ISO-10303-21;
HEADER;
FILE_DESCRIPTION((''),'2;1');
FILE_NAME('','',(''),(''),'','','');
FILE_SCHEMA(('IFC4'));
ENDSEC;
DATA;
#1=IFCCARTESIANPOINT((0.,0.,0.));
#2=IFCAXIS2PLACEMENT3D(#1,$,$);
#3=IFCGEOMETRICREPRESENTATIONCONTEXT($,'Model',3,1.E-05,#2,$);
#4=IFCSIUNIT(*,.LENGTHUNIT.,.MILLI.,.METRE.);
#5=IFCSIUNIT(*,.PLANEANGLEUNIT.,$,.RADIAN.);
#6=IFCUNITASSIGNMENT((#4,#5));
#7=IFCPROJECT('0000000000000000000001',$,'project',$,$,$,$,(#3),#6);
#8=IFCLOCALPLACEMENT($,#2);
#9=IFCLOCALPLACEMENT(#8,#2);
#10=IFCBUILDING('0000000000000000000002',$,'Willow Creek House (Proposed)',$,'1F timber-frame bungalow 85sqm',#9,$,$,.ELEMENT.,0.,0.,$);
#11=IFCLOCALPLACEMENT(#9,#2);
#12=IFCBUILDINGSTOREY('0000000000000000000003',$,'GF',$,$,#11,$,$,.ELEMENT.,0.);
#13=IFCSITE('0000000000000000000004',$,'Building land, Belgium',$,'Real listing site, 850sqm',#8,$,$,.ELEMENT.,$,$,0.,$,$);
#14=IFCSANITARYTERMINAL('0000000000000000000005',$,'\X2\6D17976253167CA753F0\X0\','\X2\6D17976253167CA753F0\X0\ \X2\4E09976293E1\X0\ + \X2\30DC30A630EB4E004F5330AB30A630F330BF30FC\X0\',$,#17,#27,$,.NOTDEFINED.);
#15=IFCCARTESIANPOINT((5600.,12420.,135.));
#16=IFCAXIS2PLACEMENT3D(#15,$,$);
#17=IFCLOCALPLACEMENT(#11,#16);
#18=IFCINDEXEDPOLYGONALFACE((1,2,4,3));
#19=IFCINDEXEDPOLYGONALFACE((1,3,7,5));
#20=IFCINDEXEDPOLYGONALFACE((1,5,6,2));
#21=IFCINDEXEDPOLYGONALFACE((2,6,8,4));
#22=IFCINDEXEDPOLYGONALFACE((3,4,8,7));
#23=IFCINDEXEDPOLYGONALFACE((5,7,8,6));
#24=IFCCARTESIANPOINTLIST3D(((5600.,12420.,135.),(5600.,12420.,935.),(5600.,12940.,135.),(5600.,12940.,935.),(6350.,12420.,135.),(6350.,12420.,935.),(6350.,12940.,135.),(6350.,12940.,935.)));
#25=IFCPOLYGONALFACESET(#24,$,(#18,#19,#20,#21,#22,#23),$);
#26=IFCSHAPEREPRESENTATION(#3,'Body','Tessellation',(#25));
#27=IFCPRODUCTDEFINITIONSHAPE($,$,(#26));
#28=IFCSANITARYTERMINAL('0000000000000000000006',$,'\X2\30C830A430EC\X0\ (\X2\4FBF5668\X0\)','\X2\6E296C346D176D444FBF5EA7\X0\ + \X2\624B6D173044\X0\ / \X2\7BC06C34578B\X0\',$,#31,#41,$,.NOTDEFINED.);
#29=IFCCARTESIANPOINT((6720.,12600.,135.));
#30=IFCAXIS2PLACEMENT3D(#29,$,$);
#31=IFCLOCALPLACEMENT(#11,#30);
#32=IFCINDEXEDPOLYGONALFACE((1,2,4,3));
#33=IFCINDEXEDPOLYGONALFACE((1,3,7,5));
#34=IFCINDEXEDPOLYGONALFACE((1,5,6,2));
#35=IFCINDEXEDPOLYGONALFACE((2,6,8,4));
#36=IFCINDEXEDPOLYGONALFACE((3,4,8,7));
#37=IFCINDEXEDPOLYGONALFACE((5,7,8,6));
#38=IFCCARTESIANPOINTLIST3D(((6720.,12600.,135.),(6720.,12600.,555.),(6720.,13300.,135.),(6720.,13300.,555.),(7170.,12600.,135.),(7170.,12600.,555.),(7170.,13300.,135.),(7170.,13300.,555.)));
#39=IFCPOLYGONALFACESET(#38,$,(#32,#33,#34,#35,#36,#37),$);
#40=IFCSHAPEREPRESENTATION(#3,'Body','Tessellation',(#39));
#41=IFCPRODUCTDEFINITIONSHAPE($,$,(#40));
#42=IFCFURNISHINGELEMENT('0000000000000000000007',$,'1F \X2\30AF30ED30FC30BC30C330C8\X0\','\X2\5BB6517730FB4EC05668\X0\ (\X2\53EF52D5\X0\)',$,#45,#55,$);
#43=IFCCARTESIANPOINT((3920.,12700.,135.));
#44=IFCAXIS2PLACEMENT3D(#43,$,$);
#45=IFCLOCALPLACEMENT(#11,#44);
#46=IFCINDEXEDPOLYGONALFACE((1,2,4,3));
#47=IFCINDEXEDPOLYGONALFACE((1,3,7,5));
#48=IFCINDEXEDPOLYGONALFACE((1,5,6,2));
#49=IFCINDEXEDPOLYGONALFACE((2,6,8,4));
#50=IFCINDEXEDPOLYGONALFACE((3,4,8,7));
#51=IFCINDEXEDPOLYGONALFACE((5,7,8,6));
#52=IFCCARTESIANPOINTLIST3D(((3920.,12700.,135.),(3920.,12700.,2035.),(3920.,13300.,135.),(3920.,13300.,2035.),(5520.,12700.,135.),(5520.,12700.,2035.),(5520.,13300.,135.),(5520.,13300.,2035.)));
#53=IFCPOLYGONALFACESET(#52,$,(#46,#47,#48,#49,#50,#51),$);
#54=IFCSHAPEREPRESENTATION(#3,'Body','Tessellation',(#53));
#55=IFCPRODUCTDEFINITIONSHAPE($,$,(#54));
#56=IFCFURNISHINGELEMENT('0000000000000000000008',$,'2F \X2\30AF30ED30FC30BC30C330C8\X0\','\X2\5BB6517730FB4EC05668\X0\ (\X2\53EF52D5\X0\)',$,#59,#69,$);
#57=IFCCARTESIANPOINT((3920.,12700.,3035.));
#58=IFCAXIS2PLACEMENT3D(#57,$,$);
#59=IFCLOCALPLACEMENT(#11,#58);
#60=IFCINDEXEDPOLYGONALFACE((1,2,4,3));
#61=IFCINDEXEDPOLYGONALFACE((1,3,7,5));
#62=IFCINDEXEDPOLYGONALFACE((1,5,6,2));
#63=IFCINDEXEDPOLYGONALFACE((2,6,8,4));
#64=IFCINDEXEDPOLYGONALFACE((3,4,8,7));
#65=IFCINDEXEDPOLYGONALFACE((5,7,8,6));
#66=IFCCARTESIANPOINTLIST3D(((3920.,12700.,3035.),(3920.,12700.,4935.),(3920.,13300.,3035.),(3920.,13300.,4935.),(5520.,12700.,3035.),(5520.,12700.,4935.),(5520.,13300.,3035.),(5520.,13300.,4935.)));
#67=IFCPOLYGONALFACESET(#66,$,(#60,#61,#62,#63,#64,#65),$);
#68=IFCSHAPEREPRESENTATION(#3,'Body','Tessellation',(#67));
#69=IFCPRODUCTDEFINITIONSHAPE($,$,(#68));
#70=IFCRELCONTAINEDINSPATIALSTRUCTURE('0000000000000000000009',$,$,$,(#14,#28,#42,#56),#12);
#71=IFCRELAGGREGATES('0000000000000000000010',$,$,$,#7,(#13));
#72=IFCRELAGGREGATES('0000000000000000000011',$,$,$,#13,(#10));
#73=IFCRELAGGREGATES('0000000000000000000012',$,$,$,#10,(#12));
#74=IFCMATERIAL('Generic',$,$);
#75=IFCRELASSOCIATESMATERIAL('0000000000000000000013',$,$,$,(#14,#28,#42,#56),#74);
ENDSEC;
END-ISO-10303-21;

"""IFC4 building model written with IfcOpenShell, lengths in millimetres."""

from ifc_helpers import new_model, si_unit, frame, frame_2d, origin, place, context, project, spatial, rectangle, extrude, material, element, save


model = new_model("IFC4")

# Units and contexts
model_context = context("Model", 3, precision=1e-05, world=origin())
ifc_project = project(units=[si_unit("LENGTHUNIT", "METRE", prefix="MILLI"), si_unit("PLANEANGLEUNIT", "RADIAN")], contexts=[model_context])

# Site, building, storey
site_placement = place(None, origin())
site = spatial("IfcSite", under=ifc_project, at=site_placement, Name="Building land, Belgium", ObjectType="Real listing site, 850sqm", CompositionType="ELEMENT", RefElevation=0.0)
building_placement = place(site_placement, origin())
building = spatial("IfcBuilding", under=site, at=building_placement, Name="Willow Creek House (Proposed)", ObjectType="1F timber-frame bungalow 85sqm", CompositionType="ELEMENT", ElevationOfRefHeight=0.0, ElevationOfTerrain=0.0)
storey_placement = place(building_placement, origin())
storey = spatial("IfcBuildingStorey", under=building, at=storey_placement, Name="GF", CompositionType="ELEMENT", Elevation=0.0)

# Shared definitions
ifc_material_1 = material(Name="Generic")

# Sanitary terminals
sanitary_terminal_1_placement = place(storey_placement, frame((5600.0, 12420.0, 135.0)))
element("IfcSanitaryTerminal", 1, at=sanitary_terminal_1_placement, inside=storey, material=ifc_material_1, Name="洗面化粧台", Description="洗面化粧台 三面鏡 + ボウル一体カウンター", PredefinedType="NOTDEFINED", context=model_context, shape_type="SweptSolid", body=[
    extrude(rectangle(XDim=750.0, YDim=520.0, at=frame_2d((375.0, 260.0))), frame((5600.0, 12420.0, 135.0)), (0.0, 0.0, 1.0), 800.0),
])
sanitary_terminal_2_placement = place(storey_placement, frame((6720.0, 12600.0, 135.0)))
element("IfcSanitaryTerminal", 2, at=sanitary_terminal_2_placement, inside=storey, material=ifc_material_1, Name="トイレ (便器)", Description="温水洗浄便座 + 手洗い / 節水型", PredefinedType="NOTDEFINED", context=model_context, shape_type="SweptSolid", body=[
    extrude(rectangle(XDim=450.0, YDim=700.0, at=frame_2d((225.0, 350.0))), frame((6720.0, 12600.0, 135.0)), (0.0, 0.0, 1.0), 420.0),
])

# Furnishing elements
furnishing_1_placement = place(storey_placement, frame((3920.0, 12700.0, 135.0)))
element("IfcFurnishingElement", 3, at=furnishing_1_placement, inside=storey, material=ifc_material_1, Name="1F クローゼット", Description="家具・什器 (可動)", context=model_context, shape_type="SweptSolid", body=[
    extrude(rectangle(XDim=1600.0, YDim=600.0, at=frame_2d((800.0, 300.0))), frame((3920.0, 12700.0, 135.0)), (0.0, 0.0, 1.0), 1900.0),
])
furnishing_2_placement = place(storey_placement, frame((3920.0, 12700.0, 3035.0)))
element("IfcFurnishingElement", 4, at=furnishing_2_placement, inside=storey, material=ifc_material_1, Name="2F クローゼット", Description="家具・什器 (可動)", context=model_context, shape_type="SweptSolid", body=[
    extrude(rectangle(XDim=1600.0, YDim=600.0, at=frame_2d((800.0, 300.0))), frame((3920.0, 12700.0, 3035.0)), (0.0, 0.0, 1.0), 1900.0),
])

save(model, "model.ifc")
